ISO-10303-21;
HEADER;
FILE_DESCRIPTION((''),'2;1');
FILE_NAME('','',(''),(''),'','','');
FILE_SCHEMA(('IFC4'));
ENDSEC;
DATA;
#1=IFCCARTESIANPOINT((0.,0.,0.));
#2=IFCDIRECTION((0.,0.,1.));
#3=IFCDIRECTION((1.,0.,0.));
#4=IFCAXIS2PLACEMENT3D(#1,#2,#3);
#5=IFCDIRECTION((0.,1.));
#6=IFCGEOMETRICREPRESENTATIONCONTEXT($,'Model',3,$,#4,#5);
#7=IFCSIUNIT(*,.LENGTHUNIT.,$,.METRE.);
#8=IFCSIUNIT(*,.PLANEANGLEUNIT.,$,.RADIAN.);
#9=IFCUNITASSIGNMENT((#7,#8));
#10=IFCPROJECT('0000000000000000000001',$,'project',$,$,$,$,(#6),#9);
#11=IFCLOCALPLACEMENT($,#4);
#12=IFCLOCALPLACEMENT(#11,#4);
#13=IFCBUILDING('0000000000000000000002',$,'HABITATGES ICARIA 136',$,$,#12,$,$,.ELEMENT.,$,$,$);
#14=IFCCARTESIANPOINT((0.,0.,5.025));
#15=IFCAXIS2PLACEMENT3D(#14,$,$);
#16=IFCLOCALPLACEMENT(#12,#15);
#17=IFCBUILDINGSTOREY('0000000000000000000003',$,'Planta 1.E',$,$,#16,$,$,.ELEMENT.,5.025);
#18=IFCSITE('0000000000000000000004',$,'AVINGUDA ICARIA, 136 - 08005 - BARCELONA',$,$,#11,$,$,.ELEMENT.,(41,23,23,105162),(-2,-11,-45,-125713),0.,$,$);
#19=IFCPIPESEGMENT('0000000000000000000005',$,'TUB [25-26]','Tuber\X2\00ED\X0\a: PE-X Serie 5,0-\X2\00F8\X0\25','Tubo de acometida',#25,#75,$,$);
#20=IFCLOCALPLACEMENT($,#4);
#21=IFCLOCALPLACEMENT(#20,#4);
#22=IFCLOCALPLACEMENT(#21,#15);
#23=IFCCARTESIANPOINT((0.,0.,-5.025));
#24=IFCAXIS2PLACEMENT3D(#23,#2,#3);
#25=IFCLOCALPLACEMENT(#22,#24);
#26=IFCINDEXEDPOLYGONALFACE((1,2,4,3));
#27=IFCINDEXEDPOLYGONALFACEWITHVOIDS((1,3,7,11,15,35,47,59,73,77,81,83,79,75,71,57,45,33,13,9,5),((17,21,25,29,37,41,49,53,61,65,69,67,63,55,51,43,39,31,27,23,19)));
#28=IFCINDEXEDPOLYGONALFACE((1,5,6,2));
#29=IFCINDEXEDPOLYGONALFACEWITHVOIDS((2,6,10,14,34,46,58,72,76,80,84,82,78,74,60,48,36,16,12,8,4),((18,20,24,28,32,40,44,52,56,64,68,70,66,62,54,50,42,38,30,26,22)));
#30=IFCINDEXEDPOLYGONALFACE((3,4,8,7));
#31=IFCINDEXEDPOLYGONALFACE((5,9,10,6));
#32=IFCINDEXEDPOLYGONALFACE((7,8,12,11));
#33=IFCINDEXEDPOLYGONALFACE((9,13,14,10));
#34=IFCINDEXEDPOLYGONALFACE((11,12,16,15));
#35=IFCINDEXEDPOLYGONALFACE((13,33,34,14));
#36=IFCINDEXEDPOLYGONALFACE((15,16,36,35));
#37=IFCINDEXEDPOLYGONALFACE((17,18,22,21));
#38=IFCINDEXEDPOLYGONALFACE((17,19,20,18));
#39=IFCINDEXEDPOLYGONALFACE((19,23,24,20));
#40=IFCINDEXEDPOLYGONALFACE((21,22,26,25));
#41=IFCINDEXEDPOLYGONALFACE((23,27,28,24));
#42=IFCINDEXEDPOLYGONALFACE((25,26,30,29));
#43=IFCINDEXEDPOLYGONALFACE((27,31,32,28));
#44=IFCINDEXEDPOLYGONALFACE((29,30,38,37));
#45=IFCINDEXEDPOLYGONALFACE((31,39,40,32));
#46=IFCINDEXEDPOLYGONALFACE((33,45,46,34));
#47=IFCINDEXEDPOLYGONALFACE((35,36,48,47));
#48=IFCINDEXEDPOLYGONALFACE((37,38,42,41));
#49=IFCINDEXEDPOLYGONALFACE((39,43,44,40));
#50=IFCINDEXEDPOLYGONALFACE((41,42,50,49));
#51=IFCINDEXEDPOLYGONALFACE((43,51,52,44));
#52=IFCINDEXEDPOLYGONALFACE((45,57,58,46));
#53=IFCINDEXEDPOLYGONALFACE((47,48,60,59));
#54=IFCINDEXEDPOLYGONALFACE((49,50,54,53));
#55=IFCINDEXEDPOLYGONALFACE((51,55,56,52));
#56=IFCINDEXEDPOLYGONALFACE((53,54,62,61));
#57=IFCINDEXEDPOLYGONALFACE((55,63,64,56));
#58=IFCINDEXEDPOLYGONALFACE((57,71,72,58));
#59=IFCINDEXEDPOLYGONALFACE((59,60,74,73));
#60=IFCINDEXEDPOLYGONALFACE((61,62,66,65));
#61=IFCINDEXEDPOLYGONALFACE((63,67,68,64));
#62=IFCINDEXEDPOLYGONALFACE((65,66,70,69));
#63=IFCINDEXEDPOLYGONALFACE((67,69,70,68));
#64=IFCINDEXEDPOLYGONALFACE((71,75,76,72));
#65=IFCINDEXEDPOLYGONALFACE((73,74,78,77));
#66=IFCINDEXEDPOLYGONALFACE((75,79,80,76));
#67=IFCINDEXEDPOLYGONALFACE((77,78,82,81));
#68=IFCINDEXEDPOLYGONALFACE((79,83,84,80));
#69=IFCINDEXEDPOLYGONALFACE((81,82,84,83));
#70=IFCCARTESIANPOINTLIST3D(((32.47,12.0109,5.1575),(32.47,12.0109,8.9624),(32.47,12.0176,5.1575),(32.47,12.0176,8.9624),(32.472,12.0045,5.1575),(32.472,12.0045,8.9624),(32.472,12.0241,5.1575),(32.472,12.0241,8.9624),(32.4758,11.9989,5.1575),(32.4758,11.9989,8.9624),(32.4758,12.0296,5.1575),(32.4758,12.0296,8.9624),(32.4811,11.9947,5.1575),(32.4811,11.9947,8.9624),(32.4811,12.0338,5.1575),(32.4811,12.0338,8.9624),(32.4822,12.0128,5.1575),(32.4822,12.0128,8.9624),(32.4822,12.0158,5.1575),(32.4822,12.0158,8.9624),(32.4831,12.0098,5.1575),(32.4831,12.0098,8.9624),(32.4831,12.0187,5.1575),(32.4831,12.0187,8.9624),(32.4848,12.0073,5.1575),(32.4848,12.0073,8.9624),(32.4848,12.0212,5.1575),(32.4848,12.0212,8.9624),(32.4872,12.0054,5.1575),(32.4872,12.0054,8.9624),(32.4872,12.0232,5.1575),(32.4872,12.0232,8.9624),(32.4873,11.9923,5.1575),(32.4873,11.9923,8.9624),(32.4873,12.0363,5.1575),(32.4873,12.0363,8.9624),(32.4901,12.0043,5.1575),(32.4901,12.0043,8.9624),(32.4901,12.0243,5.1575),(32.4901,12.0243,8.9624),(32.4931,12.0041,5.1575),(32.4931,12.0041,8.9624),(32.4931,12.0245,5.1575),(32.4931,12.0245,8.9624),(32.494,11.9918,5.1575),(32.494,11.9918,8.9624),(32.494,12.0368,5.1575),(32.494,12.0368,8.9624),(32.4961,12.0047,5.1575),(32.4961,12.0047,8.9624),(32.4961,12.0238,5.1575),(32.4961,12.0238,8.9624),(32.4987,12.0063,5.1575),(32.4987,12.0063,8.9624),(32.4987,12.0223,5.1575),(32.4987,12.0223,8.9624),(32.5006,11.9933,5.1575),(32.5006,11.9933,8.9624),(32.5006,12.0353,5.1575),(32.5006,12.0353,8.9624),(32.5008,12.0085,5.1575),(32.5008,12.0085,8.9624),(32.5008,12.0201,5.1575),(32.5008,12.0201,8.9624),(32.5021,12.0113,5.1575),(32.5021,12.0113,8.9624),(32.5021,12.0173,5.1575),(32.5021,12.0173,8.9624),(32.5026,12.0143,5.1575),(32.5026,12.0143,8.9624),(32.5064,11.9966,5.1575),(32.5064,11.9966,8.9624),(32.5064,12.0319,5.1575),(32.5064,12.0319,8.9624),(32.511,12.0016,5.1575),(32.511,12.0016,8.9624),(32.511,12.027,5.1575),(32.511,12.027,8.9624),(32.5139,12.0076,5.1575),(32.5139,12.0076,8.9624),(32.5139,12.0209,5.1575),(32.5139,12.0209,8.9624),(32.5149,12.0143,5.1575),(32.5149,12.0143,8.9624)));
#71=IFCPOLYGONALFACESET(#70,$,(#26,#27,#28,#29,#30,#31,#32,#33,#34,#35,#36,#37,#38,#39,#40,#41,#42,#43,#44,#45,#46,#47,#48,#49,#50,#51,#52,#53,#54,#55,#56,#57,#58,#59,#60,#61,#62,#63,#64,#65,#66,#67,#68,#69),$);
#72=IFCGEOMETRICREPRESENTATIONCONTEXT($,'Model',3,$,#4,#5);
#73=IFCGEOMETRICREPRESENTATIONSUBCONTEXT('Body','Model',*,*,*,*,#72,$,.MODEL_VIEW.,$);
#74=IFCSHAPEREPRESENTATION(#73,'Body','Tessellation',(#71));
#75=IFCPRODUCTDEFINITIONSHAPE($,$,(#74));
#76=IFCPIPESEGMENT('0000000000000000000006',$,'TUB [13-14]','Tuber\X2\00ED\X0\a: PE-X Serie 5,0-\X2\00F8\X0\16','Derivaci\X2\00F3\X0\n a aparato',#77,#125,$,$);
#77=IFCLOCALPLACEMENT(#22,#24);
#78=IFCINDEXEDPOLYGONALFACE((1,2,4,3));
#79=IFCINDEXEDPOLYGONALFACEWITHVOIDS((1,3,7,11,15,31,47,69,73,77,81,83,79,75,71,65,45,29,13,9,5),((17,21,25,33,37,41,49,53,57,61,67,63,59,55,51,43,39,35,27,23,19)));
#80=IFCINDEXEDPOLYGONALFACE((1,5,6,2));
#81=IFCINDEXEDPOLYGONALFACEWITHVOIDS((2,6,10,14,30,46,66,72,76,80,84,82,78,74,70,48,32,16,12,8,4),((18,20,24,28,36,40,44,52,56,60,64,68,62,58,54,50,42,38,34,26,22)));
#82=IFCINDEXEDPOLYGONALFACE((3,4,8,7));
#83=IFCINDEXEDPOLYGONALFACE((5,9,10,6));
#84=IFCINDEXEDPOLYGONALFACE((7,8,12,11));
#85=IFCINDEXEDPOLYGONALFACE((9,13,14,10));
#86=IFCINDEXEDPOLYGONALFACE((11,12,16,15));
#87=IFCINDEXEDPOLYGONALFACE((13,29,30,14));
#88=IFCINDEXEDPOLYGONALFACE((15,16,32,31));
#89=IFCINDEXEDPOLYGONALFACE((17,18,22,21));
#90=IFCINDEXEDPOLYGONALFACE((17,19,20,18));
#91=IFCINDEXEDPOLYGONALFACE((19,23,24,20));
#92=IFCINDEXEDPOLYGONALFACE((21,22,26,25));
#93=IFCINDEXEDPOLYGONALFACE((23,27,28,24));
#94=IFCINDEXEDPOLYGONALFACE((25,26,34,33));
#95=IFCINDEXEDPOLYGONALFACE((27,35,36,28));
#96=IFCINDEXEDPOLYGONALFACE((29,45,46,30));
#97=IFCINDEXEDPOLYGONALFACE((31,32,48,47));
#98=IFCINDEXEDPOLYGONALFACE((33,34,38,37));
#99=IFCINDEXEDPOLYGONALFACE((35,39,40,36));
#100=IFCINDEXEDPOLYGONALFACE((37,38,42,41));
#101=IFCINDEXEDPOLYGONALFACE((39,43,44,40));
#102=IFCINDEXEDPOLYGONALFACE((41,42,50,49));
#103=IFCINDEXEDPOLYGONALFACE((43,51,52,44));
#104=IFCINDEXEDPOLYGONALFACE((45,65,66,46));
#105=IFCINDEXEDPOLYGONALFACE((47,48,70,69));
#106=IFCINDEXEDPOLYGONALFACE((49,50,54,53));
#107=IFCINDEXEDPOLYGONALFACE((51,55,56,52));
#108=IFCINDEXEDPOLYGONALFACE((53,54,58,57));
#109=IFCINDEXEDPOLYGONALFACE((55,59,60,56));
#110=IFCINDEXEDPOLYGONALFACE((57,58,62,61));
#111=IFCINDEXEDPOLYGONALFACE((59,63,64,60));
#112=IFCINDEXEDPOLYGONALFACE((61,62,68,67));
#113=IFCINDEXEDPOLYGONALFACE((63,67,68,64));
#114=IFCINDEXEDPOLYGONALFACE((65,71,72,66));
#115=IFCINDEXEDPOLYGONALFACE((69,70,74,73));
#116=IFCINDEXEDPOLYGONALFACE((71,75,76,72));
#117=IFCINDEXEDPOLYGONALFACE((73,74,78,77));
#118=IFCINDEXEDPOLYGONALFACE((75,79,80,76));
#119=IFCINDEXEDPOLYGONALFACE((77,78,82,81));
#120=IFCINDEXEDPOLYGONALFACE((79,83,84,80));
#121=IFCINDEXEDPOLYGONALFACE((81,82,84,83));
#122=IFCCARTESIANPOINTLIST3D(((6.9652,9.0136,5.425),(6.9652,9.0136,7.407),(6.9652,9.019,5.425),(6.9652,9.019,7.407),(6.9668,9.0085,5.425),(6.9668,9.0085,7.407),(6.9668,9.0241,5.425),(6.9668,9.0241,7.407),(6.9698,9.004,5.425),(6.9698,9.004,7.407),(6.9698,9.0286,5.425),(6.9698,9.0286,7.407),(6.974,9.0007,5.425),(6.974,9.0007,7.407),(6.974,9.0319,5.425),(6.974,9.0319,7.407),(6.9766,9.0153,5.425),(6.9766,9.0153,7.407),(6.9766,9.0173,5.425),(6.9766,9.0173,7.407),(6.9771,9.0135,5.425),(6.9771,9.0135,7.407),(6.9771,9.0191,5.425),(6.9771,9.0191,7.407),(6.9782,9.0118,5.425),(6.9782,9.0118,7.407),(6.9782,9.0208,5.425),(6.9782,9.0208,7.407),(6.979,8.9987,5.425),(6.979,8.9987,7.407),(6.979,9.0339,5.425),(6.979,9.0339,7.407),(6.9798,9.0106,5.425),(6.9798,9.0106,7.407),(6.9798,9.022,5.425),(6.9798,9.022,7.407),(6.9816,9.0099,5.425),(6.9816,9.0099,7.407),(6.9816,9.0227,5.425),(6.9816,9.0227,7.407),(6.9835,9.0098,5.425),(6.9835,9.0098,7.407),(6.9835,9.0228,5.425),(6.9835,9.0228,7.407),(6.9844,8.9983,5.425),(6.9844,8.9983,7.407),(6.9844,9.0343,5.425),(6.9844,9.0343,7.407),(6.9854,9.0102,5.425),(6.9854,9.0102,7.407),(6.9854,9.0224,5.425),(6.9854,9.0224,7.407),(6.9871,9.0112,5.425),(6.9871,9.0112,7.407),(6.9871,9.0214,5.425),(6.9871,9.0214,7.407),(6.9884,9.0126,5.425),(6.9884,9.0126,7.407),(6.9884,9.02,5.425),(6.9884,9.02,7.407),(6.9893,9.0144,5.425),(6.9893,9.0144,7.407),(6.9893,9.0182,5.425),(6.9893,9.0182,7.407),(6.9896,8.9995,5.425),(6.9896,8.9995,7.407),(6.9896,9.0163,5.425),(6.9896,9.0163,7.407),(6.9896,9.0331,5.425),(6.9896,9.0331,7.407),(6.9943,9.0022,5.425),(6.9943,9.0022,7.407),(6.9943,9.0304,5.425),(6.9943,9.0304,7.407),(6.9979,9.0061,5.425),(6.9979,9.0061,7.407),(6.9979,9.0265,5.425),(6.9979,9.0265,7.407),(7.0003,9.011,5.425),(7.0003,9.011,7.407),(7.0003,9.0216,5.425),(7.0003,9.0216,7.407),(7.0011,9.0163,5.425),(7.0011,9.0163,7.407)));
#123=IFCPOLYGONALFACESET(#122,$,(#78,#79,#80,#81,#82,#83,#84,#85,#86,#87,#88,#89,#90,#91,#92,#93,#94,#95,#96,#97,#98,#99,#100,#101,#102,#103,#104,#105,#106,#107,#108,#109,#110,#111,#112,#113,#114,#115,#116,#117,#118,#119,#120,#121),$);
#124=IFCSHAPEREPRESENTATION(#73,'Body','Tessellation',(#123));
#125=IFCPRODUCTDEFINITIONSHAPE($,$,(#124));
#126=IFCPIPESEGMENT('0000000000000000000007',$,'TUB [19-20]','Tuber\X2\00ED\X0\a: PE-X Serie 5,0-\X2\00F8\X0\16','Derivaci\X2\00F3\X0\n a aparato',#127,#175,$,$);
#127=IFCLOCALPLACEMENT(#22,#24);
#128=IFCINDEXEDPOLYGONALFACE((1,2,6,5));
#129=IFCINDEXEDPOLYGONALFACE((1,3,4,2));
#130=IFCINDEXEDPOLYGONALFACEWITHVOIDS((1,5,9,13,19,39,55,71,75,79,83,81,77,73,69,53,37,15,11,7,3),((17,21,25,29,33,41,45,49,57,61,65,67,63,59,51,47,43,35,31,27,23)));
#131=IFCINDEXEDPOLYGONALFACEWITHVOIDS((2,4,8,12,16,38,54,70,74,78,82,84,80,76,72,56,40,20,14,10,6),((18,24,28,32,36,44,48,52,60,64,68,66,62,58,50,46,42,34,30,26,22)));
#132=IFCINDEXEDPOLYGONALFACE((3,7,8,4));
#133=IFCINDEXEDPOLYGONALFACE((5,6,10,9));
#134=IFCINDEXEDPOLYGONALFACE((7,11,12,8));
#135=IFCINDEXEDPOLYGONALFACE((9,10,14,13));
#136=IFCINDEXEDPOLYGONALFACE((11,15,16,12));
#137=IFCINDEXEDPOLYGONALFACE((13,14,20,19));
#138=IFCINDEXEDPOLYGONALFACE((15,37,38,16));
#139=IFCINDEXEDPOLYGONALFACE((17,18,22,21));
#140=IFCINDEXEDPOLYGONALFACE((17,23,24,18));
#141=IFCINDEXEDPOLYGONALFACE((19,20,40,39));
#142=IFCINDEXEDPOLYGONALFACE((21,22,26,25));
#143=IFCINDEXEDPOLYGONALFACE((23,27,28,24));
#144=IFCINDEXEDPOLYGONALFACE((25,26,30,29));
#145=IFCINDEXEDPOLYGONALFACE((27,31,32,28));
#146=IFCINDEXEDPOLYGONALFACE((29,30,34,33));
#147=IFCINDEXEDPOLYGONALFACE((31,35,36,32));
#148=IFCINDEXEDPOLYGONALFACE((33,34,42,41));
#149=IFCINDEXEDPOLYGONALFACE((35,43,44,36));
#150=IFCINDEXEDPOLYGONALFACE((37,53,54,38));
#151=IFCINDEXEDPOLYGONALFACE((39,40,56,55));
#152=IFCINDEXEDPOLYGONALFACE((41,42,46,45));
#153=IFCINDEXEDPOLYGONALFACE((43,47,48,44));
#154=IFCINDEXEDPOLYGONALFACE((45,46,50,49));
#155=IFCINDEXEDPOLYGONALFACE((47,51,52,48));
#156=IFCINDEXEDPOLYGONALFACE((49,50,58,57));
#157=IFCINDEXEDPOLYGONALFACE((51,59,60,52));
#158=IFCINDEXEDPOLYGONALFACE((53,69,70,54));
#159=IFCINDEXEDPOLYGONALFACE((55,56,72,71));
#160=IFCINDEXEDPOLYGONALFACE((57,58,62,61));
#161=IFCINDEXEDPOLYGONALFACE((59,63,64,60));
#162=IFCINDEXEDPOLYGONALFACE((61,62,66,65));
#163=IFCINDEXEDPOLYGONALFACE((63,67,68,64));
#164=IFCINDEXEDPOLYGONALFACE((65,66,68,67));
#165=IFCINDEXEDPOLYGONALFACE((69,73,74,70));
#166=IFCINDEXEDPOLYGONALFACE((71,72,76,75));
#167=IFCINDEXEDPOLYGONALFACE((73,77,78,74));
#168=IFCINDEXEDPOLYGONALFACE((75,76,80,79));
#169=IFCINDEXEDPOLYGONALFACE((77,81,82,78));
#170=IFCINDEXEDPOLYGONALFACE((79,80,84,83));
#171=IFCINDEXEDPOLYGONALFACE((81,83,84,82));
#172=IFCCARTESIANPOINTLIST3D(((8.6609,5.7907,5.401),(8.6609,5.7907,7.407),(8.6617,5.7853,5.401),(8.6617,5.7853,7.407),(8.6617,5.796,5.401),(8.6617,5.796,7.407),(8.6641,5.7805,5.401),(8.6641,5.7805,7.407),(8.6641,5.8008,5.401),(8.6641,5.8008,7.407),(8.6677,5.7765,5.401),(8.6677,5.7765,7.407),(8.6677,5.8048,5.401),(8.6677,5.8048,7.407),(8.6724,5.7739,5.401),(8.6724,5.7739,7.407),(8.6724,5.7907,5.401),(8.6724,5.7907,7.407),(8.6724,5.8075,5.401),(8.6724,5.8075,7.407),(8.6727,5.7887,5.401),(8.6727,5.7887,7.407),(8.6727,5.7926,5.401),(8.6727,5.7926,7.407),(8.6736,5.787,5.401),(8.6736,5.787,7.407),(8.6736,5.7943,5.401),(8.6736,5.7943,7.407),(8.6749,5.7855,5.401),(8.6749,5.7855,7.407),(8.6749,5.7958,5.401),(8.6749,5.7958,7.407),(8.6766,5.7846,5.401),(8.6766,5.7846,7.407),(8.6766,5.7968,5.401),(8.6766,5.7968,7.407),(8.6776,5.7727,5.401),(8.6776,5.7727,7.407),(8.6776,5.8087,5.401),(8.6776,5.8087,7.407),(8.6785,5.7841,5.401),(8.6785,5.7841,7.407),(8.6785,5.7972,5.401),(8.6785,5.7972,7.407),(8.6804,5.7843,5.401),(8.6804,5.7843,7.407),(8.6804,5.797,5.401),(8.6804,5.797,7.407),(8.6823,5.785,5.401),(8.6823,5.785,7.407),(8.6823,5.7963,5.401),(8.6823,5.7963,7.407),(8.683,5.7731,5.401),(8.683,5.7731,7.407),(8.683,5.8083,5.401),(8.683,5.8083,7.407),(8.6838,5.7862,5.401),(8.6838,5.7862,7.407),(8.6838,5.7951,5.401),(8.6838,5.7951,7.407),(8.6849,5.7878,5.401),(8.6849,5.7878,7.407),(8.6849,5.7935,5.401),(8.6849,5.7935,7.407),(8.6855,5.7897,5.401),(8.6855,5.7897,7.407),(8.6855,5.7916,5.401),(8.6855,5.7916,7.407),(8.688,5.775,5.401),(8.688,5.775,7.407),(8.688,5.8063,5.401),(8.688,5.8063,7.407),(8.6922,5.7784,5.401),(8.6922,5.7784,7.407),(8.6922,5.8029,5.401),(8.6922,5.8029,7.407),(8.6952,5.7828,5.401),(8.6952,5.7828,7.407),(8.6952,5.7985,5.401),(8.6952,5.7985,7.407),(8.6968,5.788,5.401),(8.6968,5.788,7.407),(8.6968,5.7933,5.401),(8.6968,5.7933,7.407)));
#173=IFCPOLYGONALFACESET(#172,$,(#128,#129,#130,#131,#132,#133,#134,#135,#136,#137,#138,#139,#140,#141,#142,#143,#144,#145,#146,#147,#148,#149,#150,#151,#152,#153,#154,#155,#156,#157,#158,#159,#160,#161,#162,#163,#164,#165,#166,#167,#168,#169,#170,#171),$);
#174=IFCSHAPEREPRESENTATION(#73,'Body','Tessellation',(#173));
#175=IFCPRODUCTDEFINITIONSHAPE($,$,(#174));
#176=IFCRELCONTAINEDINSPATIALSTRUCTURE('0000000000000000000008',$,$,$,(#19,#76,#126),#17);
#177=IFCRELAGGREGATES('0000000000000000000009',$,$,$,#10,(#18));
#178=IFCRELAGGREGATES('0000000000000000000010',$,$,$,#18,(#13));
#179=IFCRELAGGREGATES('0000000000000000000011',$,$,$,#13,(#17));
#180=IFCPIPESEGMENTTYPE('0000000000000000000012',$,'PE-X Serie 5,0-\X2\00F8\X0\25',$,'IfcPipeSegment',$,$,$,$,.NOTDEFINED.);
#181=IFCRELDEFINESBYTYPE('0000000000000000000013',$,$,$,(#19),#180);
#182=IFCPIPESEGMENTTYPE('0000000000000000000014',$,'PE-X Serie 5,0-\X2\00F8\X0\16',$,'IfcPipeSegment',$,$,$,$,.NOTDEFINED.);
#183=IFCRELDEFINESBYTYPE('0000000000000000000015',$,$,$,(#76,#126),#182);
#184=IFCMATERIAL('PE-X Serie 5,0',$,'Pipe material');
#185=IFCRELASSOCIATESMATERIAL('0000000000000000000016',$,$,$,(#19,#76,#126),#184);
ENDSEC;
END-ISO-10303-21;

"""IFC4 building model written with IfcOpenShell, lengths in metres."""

from ifc_helpers import new_model, si_unit, direction, frame, origin_with_axes, origin_2d_with_axis, place, context, subcontext, project, spatial, hollow_circle, extrude, material, type_object, element, save


model = new_model("IFC4")

# Units and contexts
model_context_1 = context("Model", 3, world=origin_with_axes(), true_north=direction((0.0, 1.0)))
model_context_2 = context("Model", 3, world=origin_with_axes(), true_north=direction((0.0, 1.0)))
body_context_1 = subcontext(model_context_2, "Body", "Model", "MODEL_VIEW")
ifc_project = project(units=[si_unit("LENGTHUNIT", "METRE"), si_unit("PLANEANGLEUNIT", "RADIAN")], contexts=[model_context_1])

# Site, building, storey
site_placement = place(None, origin_with_axes())
site = spatial("IfcSite", under=ifc_project, at=site_placement, Name="AVINGUDA ICARIA, 136 - 08005 - BARCELONA", CompositionType="ELEMENT", RefLatitude=(41, 23, 23, 105162), RefLongitude=(-2, -11, -45, -125713), RefElevation=0.0)
building_placement = place(site_placement, origin_with_axes())
building = spatial("IfcBuilding", under=site, at=building_placement, Name="HABITATGES ICARIA 136", CompositionType="ELEMENT")
storey_placement = place(building_placement, frame((0.0, 0.0, 5.025)))
storey = spatial("IfcBuildingStorey", under=building, at=storey_placement, Name="Planta 1.E", CompositionType="ELEMENT", Elevation=5.025)

# Shared definitions
ifc_material_1 = material(Name="PE-X Serie 5,0", Category="Pipe material")
placement_1 = place(None, origin_with_axes())
placement_2 = place(placement_1, origin_with_axes())
placement_3 = place(placement_2, frame((0.0, 0.0, 5.025)))

# Pipe segment
pipe_segment_type_1 = type_object("IfcPipeSegmentType", Name="PE-X Serie 5,0-ø25", ApplicableOccurrence="IfcPipeSegment", PredefinedType="NOTDEFINED")
pipe_segment_1_placement = place(placement_3, frame((0.0, 0.0, -5.025), z_axis=(0.0, 0.0, 1.0), x_axis=(1.0, 0.0, 0.0)))
element("IfcPipeSegment", 1, at=pipe_segment_1_placement, inside=storey, type_object=pipe_segment_type_1, material=ifc_material_1, Name="TUB [25-26]", Description="Tubería: PE-X Serie 5,0-ø25", ObjectType="Tubo de acometida", context=body_context_1, shape_type="SweptSolid", body=[
    extrude(hollow_circle(Radius=0.0226, WallThickness=0.0123, at=origin_2d_with_axis()), frame((32.4923, 12.0143, 5.1575), z_axis=(0.0, 0.0, 1.0), x_axis=(1.0, 0.0, 0.0)), (0.0, 0.0, 1.0), 3.8049),
])

# Pipe segments
pipe_segment_type_2 = type_object("IfcPipeSegmentType", Name="PE-X Serie 5,0-ø16", ApplicableOccurrence="IfcPipeSegment", PredefinedType="NOTDEFINED")
pipe_segment_2_placement = place(placement_3, frame((0.0, 0.0, -5.025), z_axis=(0.0, 0.0, 1.0), x_axis=(1.0, 0.0, 0.0)))
element("IfcPipeSegment", 2, at=pipe_segment_2_placement, inside=storey, type_object=pipe_segment_type_2, material=ifc_material_1, Name="TUB [13-14]", Description="Tubería: PE-X Serie 5,0-ø16", ObjectType="Derivación a aparato", context=body_context_1, shape_type="SweptSolid", body=[
    extrude(hollow_circle(Radius=0.0181, WallThickness=0.0115, at=origin_2d_with_axis()), frame((6.983, 9.0163, 5.425), z_axis=(0.0, 0.0, 1.0), x_axis=(1.0, 0.0, 0.0)), (0.0, 0.0, 1.0), 1.982),
])
pipe_segment_3_placement = place(placement_3, frame((0.0, 0.0, -5.025), z_axis=(0.0, 0.0, 1.0), x_axis=(1.0, 0.0, 0.0)))
element("IfcPipeSegment", 3, at=pipe_segment_3_placement, inside=storey, type_object=pipe_segment_type_2, material=ifc_material_1, Name="TUB [19-20]", Description="Tubería: PE-X Serie 5,0-ø16", ObjectType="Derivación a aparato", context=body_context_1, shape_type="SweptSolid", body=[
    extrude(hollow_circle(Radius=0.0181, WallThickness=0.0115, at=origin_2d_with_axis()), frame((8.679, 5.7907, 7.407), z_axis=(0.0, 0.0, -1.0), x_axis=(-1.0, 0.0, 0.0)), (0.0, 0.0, 1.0), 2.006),
])

save(model, "model.ifc")
